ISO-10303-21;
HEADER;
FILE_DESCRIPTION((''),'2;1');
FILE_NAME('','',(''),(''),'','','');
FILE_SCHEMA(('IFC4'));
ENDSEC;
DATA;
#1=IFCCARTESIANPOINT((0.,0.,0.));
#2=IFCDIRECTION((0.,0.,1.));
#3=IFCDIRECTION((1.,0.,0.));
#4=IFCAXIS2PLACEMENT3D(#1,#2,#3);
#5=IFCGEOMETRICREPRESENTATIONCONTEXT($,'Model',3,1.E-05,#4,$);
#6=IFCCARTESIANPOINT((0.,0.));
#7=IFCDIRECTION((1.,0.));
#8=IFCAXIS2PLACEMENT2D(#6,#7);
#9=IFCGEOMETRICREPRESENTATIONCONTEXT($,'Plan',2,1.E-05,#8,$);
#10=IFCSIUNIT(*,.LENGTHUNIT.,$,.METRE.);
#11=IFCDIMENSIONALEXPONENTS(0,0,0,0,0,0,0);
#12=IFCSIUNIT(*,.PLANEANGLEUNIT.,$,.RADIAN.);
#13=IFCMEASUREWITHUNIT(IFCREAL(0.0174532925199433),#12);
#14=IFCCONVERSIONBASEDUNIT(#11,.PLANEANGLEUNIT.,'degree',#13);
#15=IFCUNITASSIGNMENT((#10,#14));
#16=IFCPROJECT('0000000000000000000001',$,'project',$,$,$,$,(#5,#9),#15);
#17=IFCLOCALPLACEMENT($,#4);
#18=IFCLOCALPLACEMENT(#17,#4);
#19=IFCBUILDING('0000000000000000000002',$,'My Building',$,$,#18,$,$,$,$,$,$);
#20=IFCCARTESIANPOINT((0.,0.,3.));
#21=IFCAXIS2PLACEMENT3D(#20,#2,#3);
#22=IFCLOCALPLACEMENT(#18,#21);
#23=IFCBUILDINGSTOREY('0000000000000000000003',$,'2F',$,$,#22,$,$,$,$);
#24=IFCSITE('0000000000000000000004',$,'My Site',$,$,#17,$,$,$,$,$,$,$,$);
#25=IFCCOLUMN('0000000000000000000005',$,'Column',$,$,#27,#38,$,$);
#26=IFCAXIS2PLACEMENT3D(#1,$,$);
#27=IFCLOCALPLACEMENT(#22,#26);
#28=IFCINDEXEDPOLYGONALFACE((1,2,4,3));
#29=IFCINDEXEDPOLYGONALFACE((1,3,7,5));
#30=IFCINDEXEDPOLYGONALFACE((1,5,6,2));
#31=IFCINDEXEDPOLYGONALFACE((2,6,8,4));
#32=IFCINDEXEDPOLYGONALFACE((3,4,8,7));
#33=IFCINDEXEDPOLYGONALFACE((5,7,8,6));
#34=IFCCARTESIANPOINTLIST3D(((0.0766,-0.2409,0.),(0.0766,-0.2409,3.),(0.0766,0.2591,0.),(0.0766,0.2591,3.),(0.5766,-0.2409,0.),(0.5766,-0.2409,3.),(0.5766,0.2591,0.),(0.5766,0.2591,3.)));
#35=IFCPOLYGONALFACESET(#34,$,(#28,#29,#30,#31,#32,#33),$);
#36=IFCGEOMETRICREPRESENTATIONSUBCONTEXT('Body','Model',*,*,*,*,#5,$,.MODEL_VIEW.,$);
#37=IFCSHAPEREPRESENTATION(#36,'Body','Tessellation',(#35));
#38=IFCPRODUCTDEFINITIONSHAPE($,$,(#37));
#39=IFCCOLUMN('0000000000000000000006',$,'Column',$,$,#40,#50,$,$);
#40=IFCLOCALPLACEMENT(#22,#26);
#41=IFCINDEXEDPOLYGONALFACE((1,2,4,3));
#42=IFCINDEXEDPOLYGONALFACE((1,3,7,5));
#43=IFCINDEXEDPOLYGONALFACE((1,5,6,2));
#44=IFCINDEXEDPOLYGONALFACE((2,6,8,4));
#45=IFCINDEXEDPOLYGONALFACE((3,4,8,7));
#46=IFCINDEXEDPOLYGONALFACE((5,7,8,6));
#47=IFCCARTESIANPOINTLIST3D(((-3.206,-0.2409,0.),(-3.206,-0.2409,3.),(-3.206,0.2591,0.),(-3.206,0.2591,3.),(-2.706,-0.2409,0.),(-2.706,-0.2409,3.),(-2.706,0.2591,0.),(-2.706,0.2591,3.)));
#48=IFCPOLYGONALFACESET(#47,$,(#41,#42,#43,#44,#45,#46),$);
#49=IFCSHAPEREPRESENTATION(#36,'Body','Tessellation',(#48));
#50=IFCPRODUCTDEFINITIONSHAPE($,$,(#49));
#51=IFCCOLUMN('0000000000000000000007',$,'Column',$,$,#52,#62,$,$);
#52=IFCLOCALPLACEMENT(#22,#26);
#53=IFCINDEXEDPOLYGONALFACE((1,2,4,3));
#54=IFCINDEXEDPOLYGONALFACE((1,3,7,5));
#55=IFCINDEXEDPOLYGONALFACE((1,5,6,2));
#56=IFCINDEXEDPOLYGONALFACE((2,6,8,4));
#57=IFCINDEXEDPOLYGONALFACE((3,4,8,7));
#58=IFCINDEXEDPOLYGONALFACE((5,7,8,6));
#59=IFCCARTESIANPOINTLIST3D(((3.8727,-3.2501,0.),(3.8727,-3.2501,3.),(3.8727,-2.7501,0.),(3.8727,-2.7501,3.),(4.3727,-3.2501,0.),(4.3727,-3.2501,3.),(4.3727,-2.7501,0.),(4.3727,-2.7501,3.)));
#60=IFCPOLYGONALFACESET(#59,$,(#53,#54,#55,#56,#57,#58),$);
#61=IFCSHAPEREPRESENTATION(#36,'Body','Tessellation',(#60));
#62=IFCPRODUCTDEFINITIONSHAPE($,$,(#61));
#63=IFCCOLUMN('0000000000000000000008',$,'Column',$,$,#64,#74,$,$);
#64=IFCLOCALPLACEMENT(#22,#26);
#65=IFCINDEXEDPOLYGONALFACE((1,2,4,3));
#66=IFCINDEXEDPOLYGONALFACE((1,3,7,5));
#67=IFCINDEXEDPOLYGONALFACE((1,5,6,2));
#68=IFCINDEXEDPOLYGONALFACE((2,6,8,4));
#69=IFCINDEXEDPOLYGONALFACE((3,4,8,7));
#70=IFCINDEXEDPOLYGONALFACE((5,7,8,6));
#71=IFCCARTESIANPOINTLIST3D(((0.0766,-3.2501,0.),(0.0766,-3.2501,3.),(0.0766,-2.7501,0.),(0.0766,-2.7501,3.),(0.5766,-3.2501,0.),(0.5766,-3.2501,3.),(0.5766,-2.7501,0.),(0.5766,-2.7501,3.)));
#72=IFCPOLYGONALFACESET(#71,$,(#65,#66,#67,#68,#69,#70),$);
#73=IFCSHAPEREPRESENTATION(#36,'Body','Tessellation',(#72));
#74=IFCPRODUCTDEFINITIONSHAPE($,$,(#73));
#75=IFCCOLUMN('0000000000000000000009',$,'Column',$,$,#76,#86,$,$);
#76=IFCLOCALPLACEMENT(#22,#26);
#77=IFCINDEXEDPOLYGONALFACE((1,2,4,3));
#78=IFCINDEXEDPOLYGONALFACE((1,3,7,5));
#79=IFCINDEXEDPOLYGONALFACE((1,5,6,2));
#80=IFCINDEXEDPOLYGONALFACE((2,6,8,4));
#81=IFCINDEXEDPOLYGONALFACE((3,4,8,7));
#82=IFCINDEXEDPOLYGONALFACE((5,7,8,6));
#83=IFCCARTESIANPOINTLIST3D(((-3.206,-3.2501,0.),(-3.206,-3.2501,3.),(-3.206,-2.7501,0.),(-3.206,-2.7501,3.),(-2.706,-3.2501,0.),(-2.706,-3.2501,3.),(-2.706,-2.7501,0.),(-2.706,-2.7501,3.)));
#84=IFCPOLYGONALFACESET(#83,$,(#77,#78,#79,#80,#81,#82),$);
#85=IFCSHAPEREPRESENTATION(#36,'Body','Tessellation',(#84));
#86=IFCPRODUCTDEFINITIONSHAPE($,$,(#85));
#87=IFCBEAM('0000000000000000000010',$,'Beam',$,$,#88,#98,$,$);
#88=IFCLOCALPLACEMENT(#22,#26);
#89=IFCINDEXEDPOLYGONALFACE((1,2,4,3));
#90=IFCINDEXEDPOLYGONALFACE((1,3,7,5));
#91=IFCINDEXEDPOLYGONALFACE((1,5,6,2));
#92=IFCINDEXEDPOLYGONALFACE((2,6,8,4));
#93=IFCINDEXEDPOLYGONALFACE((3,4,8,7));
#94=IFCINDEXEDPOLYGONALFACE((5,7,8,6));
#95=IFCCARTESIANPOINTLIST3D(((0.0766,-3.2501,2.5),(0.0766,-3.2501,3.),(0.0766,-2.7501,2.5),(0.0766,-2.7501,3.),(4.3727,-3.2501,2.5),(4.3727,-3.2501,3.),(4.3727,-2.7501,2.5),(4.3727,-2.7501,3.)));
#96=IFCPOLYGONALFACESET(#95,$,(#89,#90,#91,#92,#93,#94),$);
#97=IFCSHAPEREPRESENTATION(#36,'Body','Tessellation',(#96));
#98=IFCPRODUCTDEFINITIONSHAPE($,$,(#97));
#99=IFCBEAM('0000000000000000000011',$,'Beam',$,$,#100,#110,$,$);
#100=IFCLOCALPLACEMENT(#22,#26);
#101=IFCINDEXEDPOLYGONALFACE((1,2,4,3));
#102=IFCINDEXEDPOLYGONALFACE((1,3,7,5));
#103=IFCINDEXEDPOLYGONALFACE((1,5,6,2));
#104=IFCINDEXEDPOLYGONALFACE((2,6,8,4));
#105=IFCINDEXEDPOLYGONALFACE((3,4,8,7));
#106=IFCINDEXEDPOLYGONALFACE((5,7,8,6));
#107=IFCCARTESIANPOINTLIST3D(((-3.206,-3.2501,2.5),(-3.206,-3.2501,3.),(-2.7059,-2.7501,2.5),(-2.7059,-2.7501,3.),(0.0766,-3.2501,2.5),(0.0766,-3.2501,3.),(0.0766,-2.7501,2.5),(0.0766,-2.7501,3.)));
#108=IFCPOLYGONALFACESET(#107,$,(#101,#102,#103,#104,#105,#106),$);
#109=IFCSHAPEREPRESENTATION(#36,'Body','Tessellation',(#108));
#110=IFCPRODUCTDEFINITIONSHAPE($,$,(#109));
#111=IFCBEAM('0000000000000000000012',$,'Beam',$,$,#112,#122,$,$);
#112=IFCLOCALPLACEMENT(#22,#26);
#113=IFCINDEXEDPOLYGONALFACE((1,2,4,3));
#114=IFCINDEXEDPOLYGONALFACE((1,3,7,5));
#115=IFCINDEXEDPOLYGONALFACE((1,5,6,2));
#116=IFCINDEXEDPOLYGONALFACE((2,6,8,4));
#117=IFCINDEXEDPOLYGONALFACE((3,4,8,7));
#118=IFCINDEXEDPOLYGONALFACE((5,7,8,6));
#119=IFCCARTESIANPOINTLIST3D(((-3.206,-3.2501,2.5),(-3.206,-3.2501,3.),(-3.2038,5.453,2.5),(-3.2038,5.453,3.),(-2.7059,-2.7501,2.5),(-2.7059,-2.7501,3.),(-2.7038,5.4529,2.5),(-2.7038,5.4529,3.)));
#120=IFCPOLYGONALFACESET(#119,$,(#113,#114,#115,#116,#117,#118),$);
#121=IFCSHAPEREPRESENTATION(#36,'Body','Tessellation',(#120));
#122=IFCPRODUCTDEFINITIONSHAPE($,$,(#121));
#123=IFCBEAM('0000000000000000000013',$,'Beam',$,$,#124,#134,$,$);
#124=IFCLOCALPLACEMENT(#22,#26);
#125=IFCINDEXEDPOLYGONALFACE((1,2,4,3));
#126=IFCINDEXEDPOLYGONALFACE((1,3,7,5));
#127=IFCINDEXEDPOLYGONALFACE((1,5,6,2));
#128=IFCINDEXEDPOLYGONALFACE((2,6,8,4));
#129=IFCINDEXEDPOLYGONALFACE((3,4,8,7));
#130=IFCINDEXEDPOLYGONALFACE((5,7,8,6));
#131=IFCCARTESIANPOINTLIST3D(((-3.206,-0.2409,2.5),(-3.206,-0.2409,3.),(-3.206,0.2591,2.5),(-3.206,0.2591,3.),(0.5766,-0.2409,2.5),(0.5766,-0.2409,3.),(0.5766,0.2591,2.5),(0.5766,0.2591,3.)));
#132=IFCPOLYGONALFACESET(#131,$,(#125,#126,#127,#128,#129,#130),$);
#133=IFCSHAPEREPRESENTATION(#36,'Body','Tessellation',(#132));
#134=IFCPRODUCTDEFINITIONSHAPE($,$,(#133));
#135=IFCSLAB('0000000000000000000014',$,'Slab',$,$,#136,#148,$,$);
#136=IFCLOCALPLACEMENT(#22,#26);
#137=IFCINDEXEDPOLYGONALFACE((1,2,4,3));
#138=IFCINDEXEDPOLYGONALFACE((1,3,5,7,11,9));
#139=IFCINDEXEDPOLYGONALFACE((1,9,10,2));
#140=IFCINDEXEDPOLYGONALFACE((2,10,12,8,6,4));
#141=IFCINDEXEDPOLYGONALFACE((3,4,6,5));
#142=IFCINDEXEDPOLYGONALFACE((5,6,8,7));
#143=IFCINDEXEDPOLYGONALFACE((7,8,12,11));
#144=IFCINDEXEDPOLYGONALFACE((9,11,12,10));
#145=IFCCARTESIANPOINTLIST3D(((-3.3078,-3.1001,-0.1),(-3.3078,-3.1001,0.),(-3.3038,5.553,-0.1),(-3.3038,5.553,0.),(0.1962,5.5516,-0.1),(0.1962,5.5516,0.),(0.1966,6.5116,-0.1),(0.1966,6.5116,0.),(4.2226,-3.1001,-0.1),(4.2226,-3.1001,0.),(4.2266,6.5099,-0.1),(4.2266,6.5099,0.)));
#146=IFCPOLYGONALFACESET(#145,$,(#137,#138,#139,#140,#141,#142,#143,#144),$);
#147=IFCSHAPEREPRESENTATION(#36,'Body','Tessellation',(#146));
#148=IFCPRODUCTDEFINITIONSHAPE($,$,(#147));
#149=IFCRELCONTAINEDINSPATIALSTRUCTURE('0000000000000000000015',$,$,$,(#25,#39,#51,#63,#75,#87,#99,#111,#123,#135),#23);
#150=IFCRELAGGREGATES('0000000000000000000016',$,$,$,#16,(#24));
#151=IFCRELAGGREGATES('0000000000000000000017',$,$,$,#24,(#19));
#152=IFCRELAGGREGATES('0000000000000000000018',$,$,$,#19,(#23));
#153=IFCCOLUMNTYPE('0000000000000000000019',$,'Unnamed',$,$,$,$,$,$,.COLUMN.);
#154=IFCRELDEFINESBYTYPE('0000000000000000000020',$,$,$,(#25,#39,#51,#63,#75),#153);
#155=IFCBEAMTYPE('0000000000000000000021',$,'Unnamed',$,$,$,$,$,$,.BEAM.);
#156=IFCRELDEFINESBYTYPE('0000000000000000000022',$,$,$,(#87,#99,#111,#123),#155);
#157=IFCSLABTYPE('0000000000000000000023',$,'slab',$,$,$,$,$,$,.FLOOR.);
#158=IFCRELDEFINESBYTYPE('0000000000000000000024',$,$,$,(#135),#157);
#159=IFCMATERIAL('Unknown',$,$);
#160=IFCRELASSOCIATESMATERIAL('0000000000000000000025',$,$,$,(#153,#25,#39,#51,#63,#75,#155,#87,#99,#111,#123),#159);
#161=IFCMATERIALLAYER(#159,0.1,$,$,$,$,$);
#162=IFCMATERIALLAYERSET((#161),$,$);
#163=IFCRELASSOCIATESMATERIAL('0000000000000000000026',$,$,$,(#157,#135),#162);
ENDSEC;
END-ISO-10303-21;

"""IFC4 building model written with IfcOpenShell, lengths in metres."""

from ifc_helpers import new_model, entity, si_unit, converted_unit, frame, origin_with_axes, origin_2d_with_axis, place, context, subcontext, project, spatial, indexed_curve, rectangle, outline, extrude, clip, halfspace, material, layer, layer_set, layer_usage, material_profile, profile_set, profile_usage, type_object, element, save


model = new_model("IFC4")

# Units and contexts
model_context = context("Model", 3, precision=1e-05, world=origin_with_axes())
plan_context = context("Plan", 2, precision=1e-05, world=origin_2d_with_axis())
body_context_1 = subcontext(model_context, "Body", "Model", "MODEL_VIEW")
ifc_project = project(units=[si_unit("LENGTHUNIT", "METRE"), converted_unit("PLANEANGLEUNIT", "degree", entity("IfcReal", 0.0174532925199433), si_unit("PLANEANGLEUNIT", "RADIAN"), dimensions=[0, 0, 0, 0, 0, 0, 0])], contexts=[model_context, plan_context])

# Site, building, storey
site_placement = place(None, origin_with_axes())
site = spatial("IfcSite", under=ifc_project, at=site_placement, Name="My Site")
building_placement = place(site_placement, origin_with_axes())
building = spatial("IfcBuilding", under=site, at=building_placement, Name="My Building")
storey_placement = place(building_placement, frame((0.0, 0.0, 3.0), z_axis=(0.0, 0.0, 1.0), x_axis=(1.0, 0.0, 0.0)))
storey = spatial("IfcBuildingStorey", under=building, at=storey_placement, Name="2F")

# Columns
ifc_material = material(Name="Unknown")
ifc_material_profile_1 = material_profile(ifc_material, rectangle(XDim=0.5, YDim=0.5))
ifc_profile_set_1 = profile_set([ifc_material_profile_1])
ifc_profile_usage_1 = profile_usage(ifc_profile_set_1, cardinal=9)
column_type = type_object("IfcColumnType", Name="Unnamed", PredefinedType="COLUMN", material=ifc_profile_set_1)
column_1_placement = place(storey_placement, frame((0.0766, 0.2591, 0.0), z_axis=(0.0, 0.0, 1.0), x_axis=(1.0, 0.0, 0.0)))
element("IfcColumn", 1, at=column_1_placement, inside=storey, type_object=column_type, material=ifc_profile_usage_1, Name="Column", context=body_context_1, shape_type="SweptSolid", body=[
    extrude(rectangle(XDim=0.5, YDim=0.5), frame((0.25, -0.25, 0.0), z_axis=(0.0, 0.0, 1.0), x_axis=(1.0, 0.0, 0.0)), (0.0, 0.0, 1.0), 3.0),
])
ifc_profile_usage_2 = profile_usage(ifc_profile_set_1, cardinal=9)
column_2_placement = place(storey_placement, frame((-3.206, 0.2591, 0.0), z_axis=(0.0, 0.0, 1.0), x_axis=(1.0, 0.0, 0.0)))
element("IfcColumn", 2, at=column_2_placement, inside=storey, type_object=column_type, material=ifc_profile_usage_2, Name="Column", context=body_context_1, shape_type="SweptSolid", body=[
    extrude(rectangle(XDim=0.5, YDim=0.5), frame((0.25, -0.25, 0.0), z_axis=(0.0, 0.0, 1.0), x_axis=(1.0, 0.0, 0.0)), (0.0, 0.0, 1.0), 3.0),
])
ifc_profile_usage_3 = profile_usage(ifc_profile_set_1, cardinal=5)
column_3_placement = place(storey_placement, frame((4.1227, -3.0001, 0.0), z_axis=(0.0, 0.0, 1.0), x_axis=(1.0, 0.0, 0.0)))
element("IfcColumn", 3, at=column_3_placement, inside=storey, type_object=column_type, material=ifc_profile_usage_3, Name="Column", context=body_context_1, shape_type="SweptSolid", body=[
    extrude(rectangle(XDim=0.5, YDim=0.5), origin_with_axes(), (0.0, 0.0, 1.0), 3.0),
])
ifc_profile_usage_4 = profile_usage(ifc_profile_set_1, cardinal=5)
column_4_placement = place(storey_placement, frame((0.3266, -3.0001, 0.0), z_axis=(0.0, 0.0, 1.0), x_axis=(1.0, 0.0, 0.0)))
element("IfcColumn", 4, at=column_4_placement, inside=storey, type_object=column_type, material=ifc_profile_usage_4, Name="Column", context=body_context_1, shape_type="SweptSolid", body=[
    extrude(rectangle(XDim=0.5, YDim=0.5), origin_with_axes(), (0.0, 0.0, 1.0), 3.0),
])
ifc_profile_usage_5 = profile_usage(ifc_profile_set_1, cardinal=5)
column_5_placement = place(storey_placement, frame((-2.956, -3.0001, 0.0), z_axis=(0.0, 0.0, 1.0), x_axis=(1.0, 0.0, 0.0)))
element("IfcColumn", 5, at=column_5_placement, inside=storey, type_object=column_type, material=ifc_profile_usage_5, Name="Column", context=body_context_1, shape_type="SweptSolid", body=[
    extrude(rectangle(XDim=0.5, YDim=0.5), origin_with_axes(), (0.0, 0.0, 1.0), 3.0),
])

# Beams
ifc_material_profile_2 = material_profile(ifc_material, rectangle(XDim=0.5, YDim=0.5))
ifc_profile_set_2 = profile_set([ifc_material_profile_2])
ifc_profile_usage_6 = profile_usage(ifc_profile_set_2, cardinal=7)
beam_type = type_object("IfcBeamType", Name="Unnamed", PredefinedType="BEAM", material=ifc_profile_set_2)
beam_1_placement = place(storey_placement, frame((4.3727, -3.2501, 3.0), z_axis=(-1.0, 0.0, 0.0), x_axis=(0.0, -1.0, 0.0)))
element("IfcBeam", 6, at=beam_1_placement, inside=storey, type_object=beam_type, material=ifc_profile_usage_6, Name="Beam", context=body_context_1, shape_type="SweptSolid", body=[
    extrude(rectangle(XDim=0.5, YDim=0.5), frame((-0.25, -0.25, 0.0), z_axis=(0.0, 0.0, 1.0), x_axis=(1.0, 0.0, 0.0)), (0.0, 0.0, 1.0), 4.2961),
])
ifc_profile_usage_7 = profile_usage(ifc_profile_set_2, cardinal=7)
beam_2_placement = place(storey_placement, frame((0.0766, -3.2501, 3.0), z_axis=(-1.0, 0.0, 0.0), x_axis=(0.0, -1.0, 0.0)))
element("IfcBeam", 7, at=beam_2_placement, inside=storey, type_object=beam_type, material=ifc_profile_usage_7, Name="Beam", context=body_context_1, shape_type="Clipping", body=[
    clip(extrude(rectangle(XDim=0.5, YDim=0.5), frame((-0.25, -0.25, 0.0), z_axis=(0.0, 0.0, 1.0), x_axis=(1.0, 0.0, 0.0)), (0.0, 0.0, 1.0), 3.7826), halfspace(frame((0.0, -6.0, 3.2826), z_axis=(-0.707196, 0.0, 0.707018), x_axis=(0.0, 1.0, 0.0)), False)),
])
ifc_profile_usage_8 = profile_usage(ifc_profile_set_2, cardinal=7)
beam_3_placement = place(storey_placement, frame((-3.2061, -3.7501, 3.0), z_axis=(0.000251, 1.0, 0.0), x_axis=(-1.0, 0.000251, 0.0)))
element("IfcBeam", 8, at=beam_3_placement, inside=storey, type_object=beam_type, material=ifc_profile_usage_8, Name="Beam", context=body_context_1, shape_type="Clipping", body=[
    clip(extrude(rectangle(XDim=0.5, YDim=0.5), frame((-0.25, -0.25, 0.0), z_axis=(0.0, 0.0, 1.0), x_axis=(1.0, 0.0, 0.0)), (0.0, 0.0, 1.0), 9.2031), halfspace(frame((0.0, -6.0, 0.5), z_axis=(-0.707196, 0.0, -0.707018), x_axis=(0.0, 1.0, 0.0)), False)),
])
ifc_profile_usage_9 = profile_usage(ifc_profile_set_2, cardinal=7)
beam_4_placement = place(storey_placement, frame((-3.206, 0.2591, 3.0), z_axis=(1.0, 0.0, 0.0), x_axis=(0.0, 1.0, 0.0)))
element("IfcBeam", 9, at=beam_4_placement, inside=storey, type_object=beam_type, material=ifc_profile_usage_9, Name="Beam", context=body_context_1, shape_type="SweptSolid", body=[
    extrude(rectangle(XDim=0.5, YDim=0.5), frame((-0.25, -0.25, 0.0), z_axis=(0.0, 0.0, 1.0), x_axis=(1.0, 0.0, 0.0)), (0.0, 0.0, 1.0), 3.7827),
])

# Slab
ifc_layer_1 = layer(ifc_material, 0.1)
ifc_layer_set_1 = layer_set([ifc_layer_1])
ifc_layer_usage_1 = layer_usage(ifc_layer_set_1, "AXIS3", "POSITIVE", -0.1)
slab_type = type_object("IfcSlabType", Name="slab", PredefinedType="FLOOR", material=ifc_layer_set_1)
slab_placement = place(storey_placement, frame((-3.3078, -3.1001, 0.0), z_axis=(0.0, 0.0, 1.0), x_axis=(1.0, 0.0, 0.0)))
element("IfcSlab", 10, at=slab_placement, inside=storey, type_object=slab_type, material=ifc_layer_usage_1, Name="Slab", context=body_context_1, shape_type="SweptSolid", body=[
    extrude(outline(indexed_curve([(0.0, 0.0), (7.5304, 0.0), (7.5344, 9.61), (3.5044, 9.6117), (3.504, 8.6517), (0.004, 8.6531), (0.0, 0.0)])), frame((0.0, 0.0, -0.1), z_axis=(0.0, 0.0, 1.0), x_axis=(1.0, 0.0, 0.0)), (0.0, 0.0, 1.0), 0.1),
])

save(model, "model.ifc")
